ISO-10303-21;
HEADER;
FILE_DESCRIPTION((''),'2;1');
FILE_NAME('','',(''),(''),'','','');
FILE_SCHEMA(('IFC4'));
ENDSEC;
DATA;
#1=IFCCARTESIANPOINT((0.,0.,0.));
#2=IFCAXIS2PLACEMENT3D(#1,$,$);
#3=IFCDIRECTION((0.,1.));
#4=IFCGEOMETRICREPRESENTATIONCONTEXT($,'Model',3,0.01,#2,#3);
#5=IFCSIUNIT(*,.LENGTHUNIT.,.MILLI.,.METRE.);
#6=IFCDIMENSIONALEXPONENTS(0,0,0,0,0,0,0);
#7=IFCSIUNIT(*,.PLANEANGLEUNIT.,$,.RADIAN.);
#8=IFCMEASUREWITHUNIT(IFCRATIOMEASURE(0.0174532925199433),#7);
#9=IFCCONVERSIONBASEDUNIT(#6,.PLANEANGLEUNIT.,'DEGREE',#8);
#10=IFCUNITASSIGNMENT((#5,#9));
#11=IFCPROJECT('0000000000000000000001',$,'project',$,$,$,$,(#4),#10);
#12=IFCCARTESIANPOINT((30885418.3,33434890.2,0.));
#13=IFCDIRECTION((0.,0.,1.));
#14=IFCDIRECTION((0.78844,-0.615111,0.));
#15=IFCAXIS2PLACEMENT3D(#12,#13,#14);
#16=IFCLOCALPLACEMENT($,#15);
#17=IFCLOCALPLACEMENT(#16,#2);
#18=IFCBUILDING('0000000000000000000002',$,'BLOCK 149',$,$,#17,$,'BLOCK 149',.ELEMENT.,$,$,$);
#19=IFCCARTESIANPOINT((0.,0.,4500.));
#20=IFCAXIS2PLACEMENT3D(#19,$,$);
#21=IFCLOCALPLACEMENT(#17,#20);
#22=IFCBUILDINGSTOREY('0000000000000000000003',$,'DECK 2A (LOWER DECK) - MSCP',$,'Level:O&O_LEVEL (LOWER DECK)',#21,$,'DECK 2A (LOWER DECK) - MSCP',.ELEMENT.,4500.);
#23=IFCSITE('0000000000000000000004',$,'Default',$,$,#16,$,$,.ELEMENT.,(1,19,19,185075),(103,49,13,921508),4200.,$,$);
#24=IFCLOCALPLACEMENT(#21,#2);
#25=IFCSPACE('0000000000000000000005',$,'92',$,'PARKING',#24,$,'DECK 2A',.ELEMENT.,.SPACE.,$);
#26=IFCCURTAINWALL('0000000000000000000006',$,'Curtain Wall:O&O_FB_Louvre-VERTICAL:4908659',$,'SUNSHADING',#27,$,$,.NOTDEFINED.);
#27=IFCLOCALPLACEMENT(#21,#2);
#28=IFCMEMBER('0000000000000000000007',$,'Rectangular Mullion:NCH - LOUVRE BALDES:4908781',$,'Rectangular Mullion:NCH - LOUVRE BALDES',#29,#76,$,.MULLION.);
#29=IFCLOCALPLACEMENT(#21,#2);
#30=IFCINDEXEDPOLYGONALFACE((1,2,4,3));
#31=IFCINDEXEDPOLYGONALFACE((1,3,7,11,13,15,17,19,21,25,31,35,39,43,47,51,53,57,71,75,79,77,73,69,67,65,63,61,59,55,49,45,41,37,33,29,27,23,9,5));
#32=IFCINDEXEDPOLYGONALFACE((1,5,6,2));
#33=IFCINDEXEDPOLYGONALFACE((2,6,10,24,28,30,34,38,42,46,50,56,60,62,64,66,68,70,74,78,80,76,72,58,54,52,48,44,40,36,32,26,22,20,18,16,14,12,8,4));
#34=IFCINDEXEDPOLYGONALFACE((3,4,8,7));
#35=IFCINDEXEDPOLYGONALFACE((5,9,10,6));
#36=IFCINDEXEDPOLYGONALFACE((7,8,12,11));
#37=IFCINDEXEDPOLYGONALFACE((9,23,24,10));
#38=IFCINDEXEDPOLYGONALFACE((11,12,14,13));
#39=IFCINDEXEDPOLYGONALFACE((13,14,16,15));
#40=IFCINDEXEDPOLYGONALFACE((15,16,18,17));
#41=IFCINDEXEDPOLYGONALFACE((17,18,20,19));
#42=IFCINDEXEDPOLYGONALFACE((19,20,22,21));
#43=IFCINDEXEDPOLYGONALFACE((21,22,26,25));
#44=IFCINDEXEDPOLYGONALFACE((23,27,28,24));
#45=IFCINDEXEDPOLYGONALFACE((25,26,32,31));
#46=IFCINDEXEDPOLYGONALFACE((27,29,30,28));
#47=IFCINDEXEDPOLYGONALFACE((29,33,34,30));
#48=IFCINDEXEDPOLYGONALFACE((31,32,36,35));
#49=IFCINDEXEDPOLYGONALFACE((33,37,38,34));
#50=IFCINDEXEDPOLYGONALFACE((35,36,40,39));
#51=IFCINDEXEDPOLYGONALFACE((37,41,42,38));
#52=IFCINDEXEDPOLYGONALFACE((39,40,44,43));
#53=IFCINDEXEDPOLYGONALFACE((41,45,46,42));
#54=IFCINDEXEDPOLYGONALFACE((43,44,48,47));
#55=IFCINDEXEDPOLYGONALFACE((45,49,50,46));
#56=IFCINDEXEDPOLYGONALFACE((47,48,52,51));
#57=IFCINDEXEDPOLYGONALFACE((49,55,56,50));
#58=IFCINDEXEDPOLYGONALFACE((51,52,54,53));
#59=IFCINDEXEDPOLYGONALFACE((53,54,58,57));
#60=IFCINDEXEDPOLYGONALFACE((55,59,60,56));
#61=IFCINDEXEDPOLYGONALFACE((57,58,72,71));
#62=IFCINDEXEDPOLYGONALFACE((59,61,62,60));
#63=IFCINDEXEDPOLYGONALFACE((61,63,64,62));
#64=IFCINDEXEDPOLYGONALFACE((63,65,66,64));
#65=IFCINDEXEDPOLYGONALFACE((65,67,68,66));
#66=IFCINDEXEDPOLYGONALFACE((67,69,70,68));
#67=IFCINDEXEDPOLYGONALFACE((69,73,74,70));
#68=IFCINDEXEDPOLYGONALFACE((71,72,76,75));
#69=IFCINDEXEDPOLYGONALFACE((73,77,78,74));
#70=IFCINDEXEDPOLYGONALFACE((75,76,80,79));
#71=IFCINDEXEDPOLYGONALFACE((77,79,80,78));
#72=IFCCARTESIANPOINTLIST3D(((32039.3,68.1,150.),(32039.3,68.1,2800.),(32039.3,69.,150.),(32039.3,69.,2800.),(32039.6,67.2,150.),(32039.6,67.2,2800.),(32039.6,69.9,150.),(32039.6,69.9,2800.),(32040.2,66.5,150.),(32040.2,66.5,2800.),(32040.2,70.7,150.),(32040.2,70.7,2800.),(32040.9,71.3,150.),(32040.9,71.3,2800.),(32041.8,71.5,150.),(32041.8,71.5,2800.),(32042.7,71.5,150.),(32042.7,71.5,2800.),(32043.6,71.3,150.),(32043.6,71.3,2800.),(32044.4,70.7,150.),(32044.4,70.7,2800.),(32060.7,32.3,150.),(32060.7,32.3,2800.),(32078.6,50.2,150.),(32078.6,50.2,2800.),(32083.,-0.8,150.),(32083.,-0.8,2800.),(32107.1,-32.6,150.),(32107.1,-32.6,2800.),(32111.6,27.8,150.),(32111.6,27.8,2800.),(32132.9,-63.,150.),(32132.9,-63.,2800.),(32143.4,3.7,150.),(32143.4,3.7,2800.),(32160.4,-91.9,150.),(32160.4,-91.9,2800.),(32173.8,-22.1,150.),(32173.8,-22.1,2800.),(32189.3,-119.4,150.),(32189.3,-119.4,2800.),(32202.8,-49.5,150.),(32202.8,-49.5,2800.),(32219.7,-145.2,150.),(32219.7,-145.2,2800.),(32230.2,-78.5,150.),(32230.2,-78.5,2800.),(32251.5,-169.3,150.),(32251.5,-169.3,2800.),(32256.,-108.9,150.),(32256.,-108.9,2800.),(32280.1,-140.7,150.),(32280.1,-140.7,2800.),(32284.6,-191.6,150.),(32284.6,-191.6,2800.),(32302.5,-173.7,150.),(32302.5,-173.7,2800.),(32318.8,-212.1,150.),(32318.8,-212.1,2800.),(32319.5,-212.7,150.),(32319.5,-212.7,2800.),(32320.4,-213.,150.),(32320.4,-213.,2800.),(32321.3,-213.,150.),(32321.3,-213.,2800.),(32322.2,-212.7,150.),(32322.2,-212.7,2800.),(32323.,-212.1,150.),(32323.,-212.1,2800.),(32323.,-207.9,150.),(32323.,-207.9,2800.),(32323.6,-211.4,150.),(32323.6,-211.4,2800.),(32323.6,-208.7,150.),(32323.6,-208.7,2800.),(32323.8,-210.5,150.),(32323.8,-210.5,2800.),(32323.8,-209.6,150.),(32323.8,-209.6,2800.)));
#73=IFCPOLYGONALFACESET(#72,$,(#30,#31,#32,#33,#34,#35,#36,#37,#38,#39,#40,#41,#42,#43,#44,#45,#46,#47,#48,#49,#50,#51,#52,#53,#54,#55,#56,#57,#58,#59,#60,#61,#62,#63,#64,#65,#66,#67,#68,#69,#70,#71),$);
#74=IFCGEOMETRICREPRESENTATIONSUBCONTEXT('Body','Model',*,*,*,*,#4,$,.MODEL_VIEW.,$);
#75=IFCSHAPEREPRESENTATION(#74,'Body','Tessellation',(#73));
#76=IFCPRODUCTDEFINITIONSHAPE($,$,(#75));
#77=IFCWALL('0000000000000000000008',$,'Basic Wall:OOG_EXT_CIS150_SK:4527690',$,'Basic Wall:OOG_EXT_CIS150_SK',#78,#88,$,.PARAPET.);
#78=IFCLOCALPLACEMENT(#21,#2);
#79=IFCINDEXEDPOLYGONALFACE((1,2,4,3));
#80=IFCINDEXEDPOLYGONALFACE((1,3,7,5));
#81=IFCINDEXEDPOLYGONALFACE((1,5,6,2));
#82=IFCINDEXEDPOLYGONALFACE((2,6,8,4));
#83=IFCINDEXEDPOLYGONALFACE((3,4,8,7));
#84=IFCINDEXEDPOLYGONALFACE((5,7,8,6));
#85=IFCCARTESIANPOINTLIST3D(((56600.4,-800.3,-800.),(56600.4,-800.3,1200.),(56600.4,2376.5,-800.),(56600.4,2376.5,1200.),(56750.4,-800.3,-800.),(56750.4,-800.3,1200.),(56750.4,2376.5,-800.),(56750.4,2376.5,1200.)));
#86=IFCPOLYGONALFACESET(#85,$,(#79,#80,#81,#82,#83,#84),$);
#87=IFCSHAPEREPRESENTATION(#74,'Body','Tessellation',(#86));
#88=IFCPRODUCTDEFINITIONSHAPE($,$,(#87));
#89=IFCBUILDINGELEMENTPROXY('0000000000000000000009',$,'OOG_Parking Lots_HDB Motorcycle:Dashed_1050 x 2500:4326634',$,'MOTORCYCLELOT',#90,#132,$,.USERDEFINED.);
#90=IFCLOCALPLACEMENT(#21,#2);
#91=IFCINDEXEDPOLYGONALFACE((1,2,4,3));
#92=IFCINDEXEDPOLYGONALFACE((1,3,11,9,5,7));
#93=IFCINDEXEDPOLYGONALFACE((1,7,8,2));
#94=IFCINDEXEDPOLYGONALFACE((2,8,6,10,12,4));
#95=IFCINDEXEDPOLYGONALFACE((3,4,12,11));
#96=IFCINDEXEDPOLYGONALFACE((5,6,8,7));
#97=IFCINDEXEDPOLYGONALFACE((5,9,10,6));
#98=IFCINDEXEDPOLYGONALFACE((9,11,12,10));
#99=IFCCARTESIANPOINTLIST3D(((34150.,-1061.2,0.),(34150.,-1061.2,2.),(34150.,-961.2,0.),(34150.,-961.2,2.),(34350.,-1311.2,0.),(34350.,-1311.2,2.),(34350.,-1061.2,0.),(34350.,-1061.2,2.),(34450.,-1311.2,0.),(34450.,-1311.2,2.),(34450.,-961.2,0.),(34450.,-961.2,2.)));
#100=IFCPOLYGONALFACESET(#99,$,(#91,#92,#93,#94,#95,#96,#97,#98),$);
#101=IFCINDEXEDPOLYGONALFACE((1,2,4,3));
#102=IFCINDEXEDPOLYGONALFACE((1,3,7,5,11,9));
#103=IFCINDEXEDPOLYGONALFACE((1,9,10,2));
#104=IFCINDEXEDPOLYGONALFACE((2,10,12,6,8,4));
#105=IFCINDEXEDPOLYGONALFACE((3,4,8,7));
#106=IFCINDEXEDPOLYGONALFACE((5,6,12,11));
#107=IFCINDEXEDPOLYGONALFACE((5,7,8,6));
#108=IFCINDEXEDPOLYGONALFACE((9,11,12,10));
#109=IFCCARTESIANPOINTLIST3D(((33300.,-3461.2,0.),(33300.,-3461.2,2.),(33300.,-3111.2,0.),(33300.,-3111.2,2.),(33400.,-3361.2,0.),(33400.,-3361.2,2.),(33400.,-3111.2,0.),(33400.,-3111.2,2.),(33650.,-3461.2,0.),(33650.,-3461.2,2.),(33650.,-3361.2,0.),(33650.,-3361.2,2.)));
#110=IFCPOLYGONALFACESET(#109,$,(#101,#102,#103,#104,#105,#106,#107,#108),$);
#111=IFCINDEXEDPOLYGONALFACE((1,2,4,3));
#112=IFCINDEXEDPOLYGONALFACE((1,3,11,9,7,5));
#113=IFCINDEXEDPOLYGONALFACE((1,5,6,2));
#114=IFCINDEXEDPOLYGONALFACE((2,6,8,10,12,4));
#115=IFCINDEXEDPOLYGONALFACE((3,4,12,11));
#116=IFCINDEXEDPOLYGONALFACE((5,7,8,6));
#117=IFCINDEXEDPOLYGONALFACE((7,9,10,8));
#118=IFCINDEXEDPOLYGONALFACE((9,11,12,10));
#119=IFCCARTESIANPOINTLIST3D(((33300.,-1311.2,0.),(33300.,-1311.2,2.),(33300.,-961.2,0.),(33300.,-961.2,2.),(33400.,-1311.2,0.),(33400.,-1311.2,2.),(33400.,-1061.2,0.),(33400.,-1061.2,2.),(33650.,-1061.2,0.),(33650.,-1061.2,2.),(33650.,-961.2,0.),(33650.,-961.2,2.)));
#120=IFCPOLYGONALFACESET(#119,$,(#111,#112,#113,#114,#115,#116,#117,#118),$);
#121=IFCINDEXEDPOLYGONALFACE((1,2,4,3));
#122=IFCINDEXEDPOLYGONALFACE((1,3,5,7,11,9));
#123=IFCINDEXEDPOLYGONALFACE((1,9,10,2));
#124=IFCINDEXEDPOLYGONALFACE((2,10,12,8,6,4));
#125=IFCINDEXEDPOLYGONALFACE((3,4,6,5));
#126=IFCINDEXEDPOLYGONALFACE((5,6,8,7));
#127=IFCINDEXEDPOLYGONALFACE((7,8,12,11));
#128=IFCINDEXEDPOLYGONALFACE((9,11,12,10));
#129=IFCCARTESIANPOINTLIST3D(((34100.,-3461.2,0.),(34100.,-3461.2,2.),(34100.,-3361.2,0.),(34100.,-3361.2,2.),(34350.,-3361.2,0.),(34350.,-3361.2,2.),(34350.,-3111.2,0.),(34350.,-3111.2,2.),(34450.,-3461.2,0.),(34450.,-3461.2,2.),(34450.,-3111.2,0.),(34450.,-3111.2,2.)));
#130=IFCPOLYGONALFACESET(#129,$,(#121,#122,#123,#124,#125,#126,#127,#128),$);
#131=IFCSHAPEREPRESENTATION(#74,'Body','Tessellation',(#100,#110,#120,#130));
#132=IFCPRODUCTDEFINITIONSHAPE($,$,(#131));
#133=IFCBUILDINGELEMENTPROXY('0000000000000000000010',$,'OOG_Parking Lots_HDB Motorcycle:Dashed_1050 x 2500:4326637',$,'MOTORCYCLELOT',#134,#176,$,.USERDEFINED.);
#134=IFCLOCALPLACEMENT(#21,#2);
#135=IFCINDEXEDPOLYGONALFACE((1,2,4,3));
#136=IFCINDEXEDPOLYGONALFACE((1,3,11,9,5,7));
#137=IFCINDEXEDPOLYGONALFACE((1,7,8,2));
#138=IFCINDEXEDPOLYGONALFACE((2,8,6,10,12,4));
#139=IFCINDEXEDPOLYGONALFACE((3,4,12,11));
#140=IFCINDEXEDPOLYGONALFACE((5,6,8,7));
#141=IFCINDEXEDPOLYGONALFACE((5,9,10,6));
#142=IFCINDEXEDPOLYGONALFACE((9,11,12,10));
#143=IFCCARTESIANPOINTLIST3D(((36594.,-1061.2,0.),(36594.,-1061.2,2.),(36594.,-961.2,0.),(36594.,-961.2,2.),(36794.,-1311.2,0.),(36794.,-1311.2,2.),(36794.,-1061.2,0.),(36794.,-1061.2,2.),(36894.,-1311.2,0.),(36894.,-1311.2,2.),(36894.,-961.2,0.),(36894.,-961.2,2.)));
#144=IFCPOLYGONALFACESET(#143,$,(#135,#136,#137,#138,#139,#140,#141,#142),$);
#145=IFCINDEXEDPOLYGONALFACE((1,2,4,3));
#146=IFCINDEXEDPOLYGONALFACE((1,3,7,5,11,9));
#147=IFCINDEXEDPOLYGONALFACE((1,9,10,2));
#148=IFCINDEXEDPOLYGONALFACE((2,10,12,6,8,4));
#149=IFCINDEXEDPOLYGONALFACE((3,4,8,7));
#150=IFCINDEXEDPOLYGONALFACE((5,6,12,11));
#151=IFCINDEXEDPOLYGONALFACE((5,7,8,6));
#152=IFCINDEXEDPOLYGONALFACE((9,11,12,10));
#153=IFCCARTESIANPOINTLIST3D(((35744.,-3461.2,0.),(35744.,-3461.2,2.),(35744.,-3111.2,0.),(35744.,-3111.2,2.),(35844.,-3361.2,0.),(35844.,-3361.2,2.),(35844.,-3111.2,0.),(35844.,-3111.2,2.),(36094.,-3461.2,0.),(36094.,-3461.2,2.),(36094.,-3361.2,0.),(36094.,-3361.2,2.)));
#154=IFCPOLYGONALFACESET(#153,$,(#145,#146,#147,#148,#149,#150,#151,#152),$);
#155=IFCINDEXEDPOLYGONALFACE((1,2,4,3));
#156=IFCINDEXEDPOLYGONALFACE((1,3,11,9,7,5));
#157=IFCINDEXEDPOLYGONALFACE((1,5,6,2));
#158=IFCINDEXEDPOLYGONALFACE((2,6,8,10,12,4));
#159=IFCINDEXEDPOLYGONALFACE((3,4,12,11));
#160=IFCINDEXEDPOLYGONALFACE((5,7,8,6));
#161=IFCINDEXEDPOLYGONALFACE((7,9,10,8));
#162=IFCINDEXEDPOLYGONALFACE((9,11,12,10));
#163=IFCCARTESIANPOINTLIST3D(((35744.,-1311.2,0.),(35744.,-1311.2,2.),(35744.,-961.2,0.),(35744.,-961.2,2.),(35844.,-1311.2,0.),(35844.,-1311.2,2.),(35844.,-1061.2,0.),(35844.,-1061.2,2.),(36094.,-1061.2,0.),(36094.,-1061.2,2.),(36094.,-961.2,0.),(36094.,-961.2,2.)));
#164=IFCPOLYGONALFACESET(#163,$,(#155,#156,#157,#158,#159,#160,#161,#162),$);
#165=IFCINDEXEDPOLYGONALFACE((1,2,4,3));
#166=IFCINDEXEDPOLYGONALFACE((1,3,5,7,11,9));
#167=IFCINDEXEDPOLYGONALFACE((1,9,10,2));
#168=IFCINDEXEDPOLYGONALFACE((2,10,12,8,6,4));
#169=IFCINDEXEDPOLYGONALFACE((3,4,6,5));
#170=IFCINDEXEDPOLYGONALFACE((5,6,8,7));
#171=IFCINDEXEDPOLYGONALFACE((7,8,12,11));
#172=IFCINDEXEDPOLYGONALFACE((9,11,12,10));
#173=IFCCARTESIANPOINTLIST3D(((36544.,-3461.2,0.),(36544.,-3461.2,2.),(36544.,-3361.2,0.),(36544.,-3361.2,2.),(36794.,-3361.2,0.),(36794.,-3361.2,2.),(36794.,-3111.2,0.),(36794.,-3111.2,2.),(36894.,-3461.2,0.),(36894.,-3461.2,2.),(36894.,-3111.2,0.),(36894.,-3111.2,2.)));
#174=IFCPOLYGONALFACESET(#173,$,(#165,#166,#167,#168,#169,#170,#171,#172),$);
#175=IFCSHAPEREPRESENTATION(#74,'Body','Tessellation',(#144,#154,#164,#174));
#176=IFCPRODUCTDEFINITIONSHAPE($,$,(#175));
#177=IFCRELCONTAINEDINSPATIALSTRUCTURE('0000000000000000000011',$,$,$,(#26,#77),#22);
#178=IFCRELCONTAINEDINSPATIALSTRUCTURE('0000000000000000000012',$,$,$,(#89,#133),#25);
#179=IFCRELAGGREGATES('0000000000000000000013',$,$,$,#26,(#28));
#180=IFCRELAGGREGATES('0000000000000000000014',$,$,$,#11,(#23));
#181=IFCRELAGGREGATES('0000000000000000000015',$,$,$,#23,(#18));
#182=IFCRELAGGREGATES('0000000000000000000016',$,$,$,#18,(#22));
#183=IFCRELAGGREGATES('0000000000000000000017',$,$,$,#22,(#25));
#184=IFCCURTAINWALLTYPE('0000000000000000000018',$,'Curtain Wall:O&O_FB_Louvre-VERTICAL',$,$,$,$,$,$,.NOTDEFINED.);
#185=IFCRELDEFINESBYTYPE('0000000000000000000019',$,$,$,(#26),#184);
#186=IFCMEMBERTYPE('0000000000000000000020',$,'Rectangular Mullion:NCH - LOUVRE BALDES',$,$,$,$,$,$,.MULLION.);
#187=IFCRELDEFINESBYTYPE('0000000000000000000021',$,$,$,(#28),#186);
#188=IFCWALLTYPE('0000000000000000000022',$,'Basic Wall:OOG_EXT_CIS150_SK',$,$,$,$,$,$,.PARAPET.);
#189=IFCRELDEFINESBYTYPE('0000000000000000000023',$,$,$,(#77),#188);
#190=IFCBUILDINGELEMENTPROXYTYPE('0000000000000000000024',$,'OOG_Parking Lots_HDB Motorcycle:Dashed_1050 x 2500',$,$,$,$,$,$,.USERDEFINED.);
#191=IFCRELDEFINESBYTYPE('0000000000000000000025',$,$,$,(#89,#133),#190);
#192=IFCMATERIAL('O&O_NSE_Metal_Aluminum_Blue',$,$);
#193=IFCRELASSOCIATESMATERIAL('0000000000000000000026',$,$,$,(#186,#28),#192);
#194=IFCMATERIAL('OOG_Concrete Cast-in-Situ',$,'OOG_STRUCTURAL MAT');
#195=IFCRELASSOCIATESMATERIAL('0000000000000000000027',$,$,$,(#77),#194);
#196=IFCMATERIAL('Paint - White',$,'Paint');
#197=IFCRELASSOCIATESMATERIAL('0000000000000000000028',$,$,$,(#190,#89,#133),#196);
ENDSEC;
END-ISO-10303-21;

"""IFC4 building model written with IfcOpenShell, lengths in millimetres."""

from ifc_helpers import new_model, entity, si_unit, converted_unit, direction, frame, origin, place, context, subcontext, project, spatial, indexed_curve, outline, extrude, source, transform, mapped, material, type_object, type_shapes, element, aggregate, save


model = new_model("IFC4")

# Units and contexts
model_context = context("Model", 3, precision=0.01, world=origin(), true_north=direction((0.0, 1.0)))
body_context = subcontext(model_context, "Body", "Model", "MODEL_VIEW")
ifc_project = project(units=[si_unit("LENGTHUNIT", "METRE", prefix="MILLI"), converted_unit("PLANEANGLEUNIT", "DEGREE", entity("IfcRatioMeasure", 0.0174532925199433), si_unit("PLANEANGLEUNIT", "RADIAN"), dimensions=[0, 0, 0, 0, 0, 0, 0])], contexts=[model_context])

# Site, building, storey
site_placement = place(None, frame((30885418.3, 33434890.2, 0.0), z_axis=(0.0, 0.0, 1.0), x_axis=(0.78844, -0.615111, 0.0)))
site = spatial("IfcSite", under=ifc_project, at=site_placement, Name="Default", CompositionType="ELEMENT", RefLatitude=(1, 19, 19, 185075), RefLongitude=(103, 49, 13, 921508), RefElevation=4200.0)
building_placement = place(site_placement, origin())
building = spatial("IfcBuilding", under=site, at=building_placement, Name="BLOCK 149", LongName="BLOCK 149", CompositionType="ELEMENT")
storey_placement = place(building_placement, frame((0.0, 0.0, 4500.0)))
storey = spatial("IfcBuildingStorey", under=building, at=storey_placement, Name="DECK 2A (LOWER DECK) - MSCP", ObjectType="Level:O&O_LEVEL (LOWER DECK)", LongName="DECK 2A (LOWER DECK) - MSCP", CompositionType="ELEMENT", Elevation=4500.0)

# Curtain wall, member
curtain_wall_type = type_object("IfcCurtainWallType", Name="Curtain Wall:O&O_FB_Louvre-VERTICAL", PredefinedType="NOTDEFINED")
curtain_wall_placement = place(storey_placement, frame((0.0, 0.0, -4500.0)))
curtain_wall = element("IfcCurtainWall", 1, at=curtain_wall_placement, inside=storey, type_object=curtain_wall_type, Name="Curtain Wall:O&O_FB_Louvre-VERTICAL:4908659", ObjectType="SUNSHADING", PredefinedType="NOTDEFINED")
placement = place(building_placement, origin())
ifc_material_1 = material(Name="O&O_NSE_Metal_Aluminum_Blue")
member_type_1 = type_object("IfcMemberType", Name="Rectangular Mullion:NCH - LOUVRE BALDES", PredefinedType="MULLION", material=ifc_material_1)
shared_shape_1 = source(origin(), body_context, "Body", "SweptSolid", [
    extrude(outline(indexed_curve([(55.9, -188.9), (54.8, -149.1), (51.6, -109.3), (46.1, -69.8), (38.6, -30.6), (28.9, 8.1), (17.1, 46.2), (3.3, 83.6), (-12.6, 120.2), (-30.4, 155.9), (-50.1, 190.5), (-50.5, 191.4), (-51.1, 192.1), (-52.0, 192.5), (-52.9, 192.7), (-53.8, 192.6), (-54.7, 192.2), (-55.4, 191.6), (-55.8, 190.8), (-56.0, 189.9), (-55.9, 188.9), (-54.8, 149.1), (-51.6, 109.3), (-46.1, 69.8), (-38.6, 30.6), (-28.9, -8.1), (-17.1, -46.2), (-3.3, -83.6), (12.6, -120.2), (30.4, -155.9), (50.1, -190.5), (50.5, -191.4), (51.1, -192.1), (52.0, -192.5), (52.9, -192.7), (53.8, -192.6), (54.7, -192.2), (55.4, -191.6), (55.8, -190.8), (56.0, -189.9), (55.9, -188.9)], self_intersect=False)), frame((0.0, 0.0, -2650.0), z_axis=(0.0, 0.0, 1.0), x_axis=(0.490779, -0.871284, 0.0)), (0.0, 0.0, 1.0), 2650.0),
])
type_shapes(member_type_1, [shared_shape_1])
member_1_placement = place(placement, frame((32181.6, -70.7, 4650.0), z_axis=(0.0, 0.0, -1.0), x_axis=(-1.0, 0.0, 0.0)))
member_1 = element("IfcMember", 2, at=member_1_placement, type_object=member_type_1, material=ifc_material_1, Name="Rectangular Mullion:NCH - LOUVRE BALDES:4908781", ObjectType="Rectangular Mullion:NCH - LOUVRE BALDES", PredefinedType="MULLION", context=body_context, shape_type="MappedRepresentation", body=[
    mapped(shared_shape_1, transform((0.0, 0.0, 0.0), scale=1.0)),
])
aggregate(curtain_wall, [member_1])

# Wall
ifc_material_2 = material(Name="OOG_Concrete Cast-in-Situ", Category="OOG_STRUCTURAL MAT")
wall_type = type_object("IfcWallType", Name="Basic Wall:OOG_EXT_CIS150_SK", PredefinedType="PARAPET")
wall_placement = place(storey_placement, frame((56675.4, 2376.5, -800.0), z_axis=(0.0, 0.0, 1.0), x_axis=(0.0, -1.0, 0.0)))
element("IfcWall", 3, at=wall_placement, inside=storey, type_object=wall_type, material=ifc_material_2, Name="Basic Wall:OOG_EXT_CIS150_SK:4527690", ObjectType="Basic Wall:OOG_EXT_CIS150_SK", PredefinedType="PARAPET", context=body_context, shape_type="SweptSolid", body=[
    extrude(outline(indexed_curve([(3176.8, 75.0), (0.0, 75.0), (0.0, -75.0), (3176.8, -75.0), (3176.8, 75.0)], self_intersect=False)), origin(), (0.0, 0.0, 1.0), 2000.0),
])

# Shared definitions
space_placement = place(storey_placement, origin())
space = spatial("IfcSpace", under=storey, at=space_placement, Name="92", ObjectType="PARKING", LongName="DECK 2A", CompositionType="ELEMENT", PredefinedType="SPACE")

# Building element proxies
ifc_material_3 = material(Name="Paint - White", Category="Paint")
building_element_proxy_type_1 = type_object("IfcBuildingElementProxyType", Name="OOG_Parking Lots_HDB Motorcycle:Dashed_1050 x 2500", PredefinedType="USERDEFINED", material=ifc_material_3)
shared_shape_2 = source(origin(), body_context, "Body", "SweptSolid", [
    extrude(outline(indexed_curve([(-200.0, -133.3), (150.0, -133.3), (150.0, 166.7), (50.0, 166.7), (50.0, -33.3), (-200.0, -33.3), (-200.0, -133.3)], self_intersect=False)), frame((966.7, -100.0, 0.0), z_axis=(0.0, 0.0, 1.0), x_axis=(0.0, 1.0, 0.0)), (0.0, 0.0, 1.0), 2.0),
    extrude(outline(indexed_curve([(-200.0, -150.0), (150.0, -150.0), (150.0, 200.0), (50.0, 200.0), (50.0, -50.0), (-200.0, -50.0), (-200.0, -150.0)], self_intersect=False)), frame((100.0, -2300.0, 0.0), z_axis=(0.0, 0.0, 1.0), x_axis=(0.0, -1.0, 0.0)), (0.0, 0.0, 1.0), 2.0),
    extrude(outline(indexed_curve([(-200.0, -150.0), (150.0, -150.0), (150.0, 200.0), (50.0, 200.0), (50.0, -50.0), (-200.0, -50.0), (-200.0, -150.0)], self_intersect=False)), frame((100.0, -100.0, 0.0), z_axis=(0.0, 0.0, 1.0), x_axis=(-1.0, 0.0, 0.0)), (0.0, 0.0, 1.0), 2.0),
    extrude(outline(indexed_curve([(-200.0, -150.0), (150.0, -150.0), (150.0, 200.0), (50.0, 200.0), (50.0, -50.0), (-200.0, -50.0), (-200.0, -150.0)], self_intersect=False)), frame((950.0, -2300.0, 0.0)), (0.0, 0.0, 1.0), 2.0),
])
type_shapes(building_element_proxy_type_1, [shared_shape_2])
for number, where, name in (
    (4, (33350.0, -1011.2, 0.0), "OOG_Parking Lots_HDB Motorcycle:Dashed_1050 x 2500:4326634"),
    (5, (35794.0, -1011.2, 0.0), "OOG_Parking Lots_HDB Motorcycle:Dashed_1050 x 2500:4326637"),
):
    element("IfcBuildingElementProxy", number, at=place(space_placement, frame(where)), inside=space, type_object=building_element_proxy_type_1, material=ifc_material_3, Name=name, ObjectType="MOTORCYCLELOT", PredefinedType="USERDEFINED", context=body_context, shape_type="MappedRepresentation", body=[
        mapped(shared_shape_2, transform((0.0, 0.0, 0.0), scale=1.0)),
    ])

save(model, "model.ifc")
